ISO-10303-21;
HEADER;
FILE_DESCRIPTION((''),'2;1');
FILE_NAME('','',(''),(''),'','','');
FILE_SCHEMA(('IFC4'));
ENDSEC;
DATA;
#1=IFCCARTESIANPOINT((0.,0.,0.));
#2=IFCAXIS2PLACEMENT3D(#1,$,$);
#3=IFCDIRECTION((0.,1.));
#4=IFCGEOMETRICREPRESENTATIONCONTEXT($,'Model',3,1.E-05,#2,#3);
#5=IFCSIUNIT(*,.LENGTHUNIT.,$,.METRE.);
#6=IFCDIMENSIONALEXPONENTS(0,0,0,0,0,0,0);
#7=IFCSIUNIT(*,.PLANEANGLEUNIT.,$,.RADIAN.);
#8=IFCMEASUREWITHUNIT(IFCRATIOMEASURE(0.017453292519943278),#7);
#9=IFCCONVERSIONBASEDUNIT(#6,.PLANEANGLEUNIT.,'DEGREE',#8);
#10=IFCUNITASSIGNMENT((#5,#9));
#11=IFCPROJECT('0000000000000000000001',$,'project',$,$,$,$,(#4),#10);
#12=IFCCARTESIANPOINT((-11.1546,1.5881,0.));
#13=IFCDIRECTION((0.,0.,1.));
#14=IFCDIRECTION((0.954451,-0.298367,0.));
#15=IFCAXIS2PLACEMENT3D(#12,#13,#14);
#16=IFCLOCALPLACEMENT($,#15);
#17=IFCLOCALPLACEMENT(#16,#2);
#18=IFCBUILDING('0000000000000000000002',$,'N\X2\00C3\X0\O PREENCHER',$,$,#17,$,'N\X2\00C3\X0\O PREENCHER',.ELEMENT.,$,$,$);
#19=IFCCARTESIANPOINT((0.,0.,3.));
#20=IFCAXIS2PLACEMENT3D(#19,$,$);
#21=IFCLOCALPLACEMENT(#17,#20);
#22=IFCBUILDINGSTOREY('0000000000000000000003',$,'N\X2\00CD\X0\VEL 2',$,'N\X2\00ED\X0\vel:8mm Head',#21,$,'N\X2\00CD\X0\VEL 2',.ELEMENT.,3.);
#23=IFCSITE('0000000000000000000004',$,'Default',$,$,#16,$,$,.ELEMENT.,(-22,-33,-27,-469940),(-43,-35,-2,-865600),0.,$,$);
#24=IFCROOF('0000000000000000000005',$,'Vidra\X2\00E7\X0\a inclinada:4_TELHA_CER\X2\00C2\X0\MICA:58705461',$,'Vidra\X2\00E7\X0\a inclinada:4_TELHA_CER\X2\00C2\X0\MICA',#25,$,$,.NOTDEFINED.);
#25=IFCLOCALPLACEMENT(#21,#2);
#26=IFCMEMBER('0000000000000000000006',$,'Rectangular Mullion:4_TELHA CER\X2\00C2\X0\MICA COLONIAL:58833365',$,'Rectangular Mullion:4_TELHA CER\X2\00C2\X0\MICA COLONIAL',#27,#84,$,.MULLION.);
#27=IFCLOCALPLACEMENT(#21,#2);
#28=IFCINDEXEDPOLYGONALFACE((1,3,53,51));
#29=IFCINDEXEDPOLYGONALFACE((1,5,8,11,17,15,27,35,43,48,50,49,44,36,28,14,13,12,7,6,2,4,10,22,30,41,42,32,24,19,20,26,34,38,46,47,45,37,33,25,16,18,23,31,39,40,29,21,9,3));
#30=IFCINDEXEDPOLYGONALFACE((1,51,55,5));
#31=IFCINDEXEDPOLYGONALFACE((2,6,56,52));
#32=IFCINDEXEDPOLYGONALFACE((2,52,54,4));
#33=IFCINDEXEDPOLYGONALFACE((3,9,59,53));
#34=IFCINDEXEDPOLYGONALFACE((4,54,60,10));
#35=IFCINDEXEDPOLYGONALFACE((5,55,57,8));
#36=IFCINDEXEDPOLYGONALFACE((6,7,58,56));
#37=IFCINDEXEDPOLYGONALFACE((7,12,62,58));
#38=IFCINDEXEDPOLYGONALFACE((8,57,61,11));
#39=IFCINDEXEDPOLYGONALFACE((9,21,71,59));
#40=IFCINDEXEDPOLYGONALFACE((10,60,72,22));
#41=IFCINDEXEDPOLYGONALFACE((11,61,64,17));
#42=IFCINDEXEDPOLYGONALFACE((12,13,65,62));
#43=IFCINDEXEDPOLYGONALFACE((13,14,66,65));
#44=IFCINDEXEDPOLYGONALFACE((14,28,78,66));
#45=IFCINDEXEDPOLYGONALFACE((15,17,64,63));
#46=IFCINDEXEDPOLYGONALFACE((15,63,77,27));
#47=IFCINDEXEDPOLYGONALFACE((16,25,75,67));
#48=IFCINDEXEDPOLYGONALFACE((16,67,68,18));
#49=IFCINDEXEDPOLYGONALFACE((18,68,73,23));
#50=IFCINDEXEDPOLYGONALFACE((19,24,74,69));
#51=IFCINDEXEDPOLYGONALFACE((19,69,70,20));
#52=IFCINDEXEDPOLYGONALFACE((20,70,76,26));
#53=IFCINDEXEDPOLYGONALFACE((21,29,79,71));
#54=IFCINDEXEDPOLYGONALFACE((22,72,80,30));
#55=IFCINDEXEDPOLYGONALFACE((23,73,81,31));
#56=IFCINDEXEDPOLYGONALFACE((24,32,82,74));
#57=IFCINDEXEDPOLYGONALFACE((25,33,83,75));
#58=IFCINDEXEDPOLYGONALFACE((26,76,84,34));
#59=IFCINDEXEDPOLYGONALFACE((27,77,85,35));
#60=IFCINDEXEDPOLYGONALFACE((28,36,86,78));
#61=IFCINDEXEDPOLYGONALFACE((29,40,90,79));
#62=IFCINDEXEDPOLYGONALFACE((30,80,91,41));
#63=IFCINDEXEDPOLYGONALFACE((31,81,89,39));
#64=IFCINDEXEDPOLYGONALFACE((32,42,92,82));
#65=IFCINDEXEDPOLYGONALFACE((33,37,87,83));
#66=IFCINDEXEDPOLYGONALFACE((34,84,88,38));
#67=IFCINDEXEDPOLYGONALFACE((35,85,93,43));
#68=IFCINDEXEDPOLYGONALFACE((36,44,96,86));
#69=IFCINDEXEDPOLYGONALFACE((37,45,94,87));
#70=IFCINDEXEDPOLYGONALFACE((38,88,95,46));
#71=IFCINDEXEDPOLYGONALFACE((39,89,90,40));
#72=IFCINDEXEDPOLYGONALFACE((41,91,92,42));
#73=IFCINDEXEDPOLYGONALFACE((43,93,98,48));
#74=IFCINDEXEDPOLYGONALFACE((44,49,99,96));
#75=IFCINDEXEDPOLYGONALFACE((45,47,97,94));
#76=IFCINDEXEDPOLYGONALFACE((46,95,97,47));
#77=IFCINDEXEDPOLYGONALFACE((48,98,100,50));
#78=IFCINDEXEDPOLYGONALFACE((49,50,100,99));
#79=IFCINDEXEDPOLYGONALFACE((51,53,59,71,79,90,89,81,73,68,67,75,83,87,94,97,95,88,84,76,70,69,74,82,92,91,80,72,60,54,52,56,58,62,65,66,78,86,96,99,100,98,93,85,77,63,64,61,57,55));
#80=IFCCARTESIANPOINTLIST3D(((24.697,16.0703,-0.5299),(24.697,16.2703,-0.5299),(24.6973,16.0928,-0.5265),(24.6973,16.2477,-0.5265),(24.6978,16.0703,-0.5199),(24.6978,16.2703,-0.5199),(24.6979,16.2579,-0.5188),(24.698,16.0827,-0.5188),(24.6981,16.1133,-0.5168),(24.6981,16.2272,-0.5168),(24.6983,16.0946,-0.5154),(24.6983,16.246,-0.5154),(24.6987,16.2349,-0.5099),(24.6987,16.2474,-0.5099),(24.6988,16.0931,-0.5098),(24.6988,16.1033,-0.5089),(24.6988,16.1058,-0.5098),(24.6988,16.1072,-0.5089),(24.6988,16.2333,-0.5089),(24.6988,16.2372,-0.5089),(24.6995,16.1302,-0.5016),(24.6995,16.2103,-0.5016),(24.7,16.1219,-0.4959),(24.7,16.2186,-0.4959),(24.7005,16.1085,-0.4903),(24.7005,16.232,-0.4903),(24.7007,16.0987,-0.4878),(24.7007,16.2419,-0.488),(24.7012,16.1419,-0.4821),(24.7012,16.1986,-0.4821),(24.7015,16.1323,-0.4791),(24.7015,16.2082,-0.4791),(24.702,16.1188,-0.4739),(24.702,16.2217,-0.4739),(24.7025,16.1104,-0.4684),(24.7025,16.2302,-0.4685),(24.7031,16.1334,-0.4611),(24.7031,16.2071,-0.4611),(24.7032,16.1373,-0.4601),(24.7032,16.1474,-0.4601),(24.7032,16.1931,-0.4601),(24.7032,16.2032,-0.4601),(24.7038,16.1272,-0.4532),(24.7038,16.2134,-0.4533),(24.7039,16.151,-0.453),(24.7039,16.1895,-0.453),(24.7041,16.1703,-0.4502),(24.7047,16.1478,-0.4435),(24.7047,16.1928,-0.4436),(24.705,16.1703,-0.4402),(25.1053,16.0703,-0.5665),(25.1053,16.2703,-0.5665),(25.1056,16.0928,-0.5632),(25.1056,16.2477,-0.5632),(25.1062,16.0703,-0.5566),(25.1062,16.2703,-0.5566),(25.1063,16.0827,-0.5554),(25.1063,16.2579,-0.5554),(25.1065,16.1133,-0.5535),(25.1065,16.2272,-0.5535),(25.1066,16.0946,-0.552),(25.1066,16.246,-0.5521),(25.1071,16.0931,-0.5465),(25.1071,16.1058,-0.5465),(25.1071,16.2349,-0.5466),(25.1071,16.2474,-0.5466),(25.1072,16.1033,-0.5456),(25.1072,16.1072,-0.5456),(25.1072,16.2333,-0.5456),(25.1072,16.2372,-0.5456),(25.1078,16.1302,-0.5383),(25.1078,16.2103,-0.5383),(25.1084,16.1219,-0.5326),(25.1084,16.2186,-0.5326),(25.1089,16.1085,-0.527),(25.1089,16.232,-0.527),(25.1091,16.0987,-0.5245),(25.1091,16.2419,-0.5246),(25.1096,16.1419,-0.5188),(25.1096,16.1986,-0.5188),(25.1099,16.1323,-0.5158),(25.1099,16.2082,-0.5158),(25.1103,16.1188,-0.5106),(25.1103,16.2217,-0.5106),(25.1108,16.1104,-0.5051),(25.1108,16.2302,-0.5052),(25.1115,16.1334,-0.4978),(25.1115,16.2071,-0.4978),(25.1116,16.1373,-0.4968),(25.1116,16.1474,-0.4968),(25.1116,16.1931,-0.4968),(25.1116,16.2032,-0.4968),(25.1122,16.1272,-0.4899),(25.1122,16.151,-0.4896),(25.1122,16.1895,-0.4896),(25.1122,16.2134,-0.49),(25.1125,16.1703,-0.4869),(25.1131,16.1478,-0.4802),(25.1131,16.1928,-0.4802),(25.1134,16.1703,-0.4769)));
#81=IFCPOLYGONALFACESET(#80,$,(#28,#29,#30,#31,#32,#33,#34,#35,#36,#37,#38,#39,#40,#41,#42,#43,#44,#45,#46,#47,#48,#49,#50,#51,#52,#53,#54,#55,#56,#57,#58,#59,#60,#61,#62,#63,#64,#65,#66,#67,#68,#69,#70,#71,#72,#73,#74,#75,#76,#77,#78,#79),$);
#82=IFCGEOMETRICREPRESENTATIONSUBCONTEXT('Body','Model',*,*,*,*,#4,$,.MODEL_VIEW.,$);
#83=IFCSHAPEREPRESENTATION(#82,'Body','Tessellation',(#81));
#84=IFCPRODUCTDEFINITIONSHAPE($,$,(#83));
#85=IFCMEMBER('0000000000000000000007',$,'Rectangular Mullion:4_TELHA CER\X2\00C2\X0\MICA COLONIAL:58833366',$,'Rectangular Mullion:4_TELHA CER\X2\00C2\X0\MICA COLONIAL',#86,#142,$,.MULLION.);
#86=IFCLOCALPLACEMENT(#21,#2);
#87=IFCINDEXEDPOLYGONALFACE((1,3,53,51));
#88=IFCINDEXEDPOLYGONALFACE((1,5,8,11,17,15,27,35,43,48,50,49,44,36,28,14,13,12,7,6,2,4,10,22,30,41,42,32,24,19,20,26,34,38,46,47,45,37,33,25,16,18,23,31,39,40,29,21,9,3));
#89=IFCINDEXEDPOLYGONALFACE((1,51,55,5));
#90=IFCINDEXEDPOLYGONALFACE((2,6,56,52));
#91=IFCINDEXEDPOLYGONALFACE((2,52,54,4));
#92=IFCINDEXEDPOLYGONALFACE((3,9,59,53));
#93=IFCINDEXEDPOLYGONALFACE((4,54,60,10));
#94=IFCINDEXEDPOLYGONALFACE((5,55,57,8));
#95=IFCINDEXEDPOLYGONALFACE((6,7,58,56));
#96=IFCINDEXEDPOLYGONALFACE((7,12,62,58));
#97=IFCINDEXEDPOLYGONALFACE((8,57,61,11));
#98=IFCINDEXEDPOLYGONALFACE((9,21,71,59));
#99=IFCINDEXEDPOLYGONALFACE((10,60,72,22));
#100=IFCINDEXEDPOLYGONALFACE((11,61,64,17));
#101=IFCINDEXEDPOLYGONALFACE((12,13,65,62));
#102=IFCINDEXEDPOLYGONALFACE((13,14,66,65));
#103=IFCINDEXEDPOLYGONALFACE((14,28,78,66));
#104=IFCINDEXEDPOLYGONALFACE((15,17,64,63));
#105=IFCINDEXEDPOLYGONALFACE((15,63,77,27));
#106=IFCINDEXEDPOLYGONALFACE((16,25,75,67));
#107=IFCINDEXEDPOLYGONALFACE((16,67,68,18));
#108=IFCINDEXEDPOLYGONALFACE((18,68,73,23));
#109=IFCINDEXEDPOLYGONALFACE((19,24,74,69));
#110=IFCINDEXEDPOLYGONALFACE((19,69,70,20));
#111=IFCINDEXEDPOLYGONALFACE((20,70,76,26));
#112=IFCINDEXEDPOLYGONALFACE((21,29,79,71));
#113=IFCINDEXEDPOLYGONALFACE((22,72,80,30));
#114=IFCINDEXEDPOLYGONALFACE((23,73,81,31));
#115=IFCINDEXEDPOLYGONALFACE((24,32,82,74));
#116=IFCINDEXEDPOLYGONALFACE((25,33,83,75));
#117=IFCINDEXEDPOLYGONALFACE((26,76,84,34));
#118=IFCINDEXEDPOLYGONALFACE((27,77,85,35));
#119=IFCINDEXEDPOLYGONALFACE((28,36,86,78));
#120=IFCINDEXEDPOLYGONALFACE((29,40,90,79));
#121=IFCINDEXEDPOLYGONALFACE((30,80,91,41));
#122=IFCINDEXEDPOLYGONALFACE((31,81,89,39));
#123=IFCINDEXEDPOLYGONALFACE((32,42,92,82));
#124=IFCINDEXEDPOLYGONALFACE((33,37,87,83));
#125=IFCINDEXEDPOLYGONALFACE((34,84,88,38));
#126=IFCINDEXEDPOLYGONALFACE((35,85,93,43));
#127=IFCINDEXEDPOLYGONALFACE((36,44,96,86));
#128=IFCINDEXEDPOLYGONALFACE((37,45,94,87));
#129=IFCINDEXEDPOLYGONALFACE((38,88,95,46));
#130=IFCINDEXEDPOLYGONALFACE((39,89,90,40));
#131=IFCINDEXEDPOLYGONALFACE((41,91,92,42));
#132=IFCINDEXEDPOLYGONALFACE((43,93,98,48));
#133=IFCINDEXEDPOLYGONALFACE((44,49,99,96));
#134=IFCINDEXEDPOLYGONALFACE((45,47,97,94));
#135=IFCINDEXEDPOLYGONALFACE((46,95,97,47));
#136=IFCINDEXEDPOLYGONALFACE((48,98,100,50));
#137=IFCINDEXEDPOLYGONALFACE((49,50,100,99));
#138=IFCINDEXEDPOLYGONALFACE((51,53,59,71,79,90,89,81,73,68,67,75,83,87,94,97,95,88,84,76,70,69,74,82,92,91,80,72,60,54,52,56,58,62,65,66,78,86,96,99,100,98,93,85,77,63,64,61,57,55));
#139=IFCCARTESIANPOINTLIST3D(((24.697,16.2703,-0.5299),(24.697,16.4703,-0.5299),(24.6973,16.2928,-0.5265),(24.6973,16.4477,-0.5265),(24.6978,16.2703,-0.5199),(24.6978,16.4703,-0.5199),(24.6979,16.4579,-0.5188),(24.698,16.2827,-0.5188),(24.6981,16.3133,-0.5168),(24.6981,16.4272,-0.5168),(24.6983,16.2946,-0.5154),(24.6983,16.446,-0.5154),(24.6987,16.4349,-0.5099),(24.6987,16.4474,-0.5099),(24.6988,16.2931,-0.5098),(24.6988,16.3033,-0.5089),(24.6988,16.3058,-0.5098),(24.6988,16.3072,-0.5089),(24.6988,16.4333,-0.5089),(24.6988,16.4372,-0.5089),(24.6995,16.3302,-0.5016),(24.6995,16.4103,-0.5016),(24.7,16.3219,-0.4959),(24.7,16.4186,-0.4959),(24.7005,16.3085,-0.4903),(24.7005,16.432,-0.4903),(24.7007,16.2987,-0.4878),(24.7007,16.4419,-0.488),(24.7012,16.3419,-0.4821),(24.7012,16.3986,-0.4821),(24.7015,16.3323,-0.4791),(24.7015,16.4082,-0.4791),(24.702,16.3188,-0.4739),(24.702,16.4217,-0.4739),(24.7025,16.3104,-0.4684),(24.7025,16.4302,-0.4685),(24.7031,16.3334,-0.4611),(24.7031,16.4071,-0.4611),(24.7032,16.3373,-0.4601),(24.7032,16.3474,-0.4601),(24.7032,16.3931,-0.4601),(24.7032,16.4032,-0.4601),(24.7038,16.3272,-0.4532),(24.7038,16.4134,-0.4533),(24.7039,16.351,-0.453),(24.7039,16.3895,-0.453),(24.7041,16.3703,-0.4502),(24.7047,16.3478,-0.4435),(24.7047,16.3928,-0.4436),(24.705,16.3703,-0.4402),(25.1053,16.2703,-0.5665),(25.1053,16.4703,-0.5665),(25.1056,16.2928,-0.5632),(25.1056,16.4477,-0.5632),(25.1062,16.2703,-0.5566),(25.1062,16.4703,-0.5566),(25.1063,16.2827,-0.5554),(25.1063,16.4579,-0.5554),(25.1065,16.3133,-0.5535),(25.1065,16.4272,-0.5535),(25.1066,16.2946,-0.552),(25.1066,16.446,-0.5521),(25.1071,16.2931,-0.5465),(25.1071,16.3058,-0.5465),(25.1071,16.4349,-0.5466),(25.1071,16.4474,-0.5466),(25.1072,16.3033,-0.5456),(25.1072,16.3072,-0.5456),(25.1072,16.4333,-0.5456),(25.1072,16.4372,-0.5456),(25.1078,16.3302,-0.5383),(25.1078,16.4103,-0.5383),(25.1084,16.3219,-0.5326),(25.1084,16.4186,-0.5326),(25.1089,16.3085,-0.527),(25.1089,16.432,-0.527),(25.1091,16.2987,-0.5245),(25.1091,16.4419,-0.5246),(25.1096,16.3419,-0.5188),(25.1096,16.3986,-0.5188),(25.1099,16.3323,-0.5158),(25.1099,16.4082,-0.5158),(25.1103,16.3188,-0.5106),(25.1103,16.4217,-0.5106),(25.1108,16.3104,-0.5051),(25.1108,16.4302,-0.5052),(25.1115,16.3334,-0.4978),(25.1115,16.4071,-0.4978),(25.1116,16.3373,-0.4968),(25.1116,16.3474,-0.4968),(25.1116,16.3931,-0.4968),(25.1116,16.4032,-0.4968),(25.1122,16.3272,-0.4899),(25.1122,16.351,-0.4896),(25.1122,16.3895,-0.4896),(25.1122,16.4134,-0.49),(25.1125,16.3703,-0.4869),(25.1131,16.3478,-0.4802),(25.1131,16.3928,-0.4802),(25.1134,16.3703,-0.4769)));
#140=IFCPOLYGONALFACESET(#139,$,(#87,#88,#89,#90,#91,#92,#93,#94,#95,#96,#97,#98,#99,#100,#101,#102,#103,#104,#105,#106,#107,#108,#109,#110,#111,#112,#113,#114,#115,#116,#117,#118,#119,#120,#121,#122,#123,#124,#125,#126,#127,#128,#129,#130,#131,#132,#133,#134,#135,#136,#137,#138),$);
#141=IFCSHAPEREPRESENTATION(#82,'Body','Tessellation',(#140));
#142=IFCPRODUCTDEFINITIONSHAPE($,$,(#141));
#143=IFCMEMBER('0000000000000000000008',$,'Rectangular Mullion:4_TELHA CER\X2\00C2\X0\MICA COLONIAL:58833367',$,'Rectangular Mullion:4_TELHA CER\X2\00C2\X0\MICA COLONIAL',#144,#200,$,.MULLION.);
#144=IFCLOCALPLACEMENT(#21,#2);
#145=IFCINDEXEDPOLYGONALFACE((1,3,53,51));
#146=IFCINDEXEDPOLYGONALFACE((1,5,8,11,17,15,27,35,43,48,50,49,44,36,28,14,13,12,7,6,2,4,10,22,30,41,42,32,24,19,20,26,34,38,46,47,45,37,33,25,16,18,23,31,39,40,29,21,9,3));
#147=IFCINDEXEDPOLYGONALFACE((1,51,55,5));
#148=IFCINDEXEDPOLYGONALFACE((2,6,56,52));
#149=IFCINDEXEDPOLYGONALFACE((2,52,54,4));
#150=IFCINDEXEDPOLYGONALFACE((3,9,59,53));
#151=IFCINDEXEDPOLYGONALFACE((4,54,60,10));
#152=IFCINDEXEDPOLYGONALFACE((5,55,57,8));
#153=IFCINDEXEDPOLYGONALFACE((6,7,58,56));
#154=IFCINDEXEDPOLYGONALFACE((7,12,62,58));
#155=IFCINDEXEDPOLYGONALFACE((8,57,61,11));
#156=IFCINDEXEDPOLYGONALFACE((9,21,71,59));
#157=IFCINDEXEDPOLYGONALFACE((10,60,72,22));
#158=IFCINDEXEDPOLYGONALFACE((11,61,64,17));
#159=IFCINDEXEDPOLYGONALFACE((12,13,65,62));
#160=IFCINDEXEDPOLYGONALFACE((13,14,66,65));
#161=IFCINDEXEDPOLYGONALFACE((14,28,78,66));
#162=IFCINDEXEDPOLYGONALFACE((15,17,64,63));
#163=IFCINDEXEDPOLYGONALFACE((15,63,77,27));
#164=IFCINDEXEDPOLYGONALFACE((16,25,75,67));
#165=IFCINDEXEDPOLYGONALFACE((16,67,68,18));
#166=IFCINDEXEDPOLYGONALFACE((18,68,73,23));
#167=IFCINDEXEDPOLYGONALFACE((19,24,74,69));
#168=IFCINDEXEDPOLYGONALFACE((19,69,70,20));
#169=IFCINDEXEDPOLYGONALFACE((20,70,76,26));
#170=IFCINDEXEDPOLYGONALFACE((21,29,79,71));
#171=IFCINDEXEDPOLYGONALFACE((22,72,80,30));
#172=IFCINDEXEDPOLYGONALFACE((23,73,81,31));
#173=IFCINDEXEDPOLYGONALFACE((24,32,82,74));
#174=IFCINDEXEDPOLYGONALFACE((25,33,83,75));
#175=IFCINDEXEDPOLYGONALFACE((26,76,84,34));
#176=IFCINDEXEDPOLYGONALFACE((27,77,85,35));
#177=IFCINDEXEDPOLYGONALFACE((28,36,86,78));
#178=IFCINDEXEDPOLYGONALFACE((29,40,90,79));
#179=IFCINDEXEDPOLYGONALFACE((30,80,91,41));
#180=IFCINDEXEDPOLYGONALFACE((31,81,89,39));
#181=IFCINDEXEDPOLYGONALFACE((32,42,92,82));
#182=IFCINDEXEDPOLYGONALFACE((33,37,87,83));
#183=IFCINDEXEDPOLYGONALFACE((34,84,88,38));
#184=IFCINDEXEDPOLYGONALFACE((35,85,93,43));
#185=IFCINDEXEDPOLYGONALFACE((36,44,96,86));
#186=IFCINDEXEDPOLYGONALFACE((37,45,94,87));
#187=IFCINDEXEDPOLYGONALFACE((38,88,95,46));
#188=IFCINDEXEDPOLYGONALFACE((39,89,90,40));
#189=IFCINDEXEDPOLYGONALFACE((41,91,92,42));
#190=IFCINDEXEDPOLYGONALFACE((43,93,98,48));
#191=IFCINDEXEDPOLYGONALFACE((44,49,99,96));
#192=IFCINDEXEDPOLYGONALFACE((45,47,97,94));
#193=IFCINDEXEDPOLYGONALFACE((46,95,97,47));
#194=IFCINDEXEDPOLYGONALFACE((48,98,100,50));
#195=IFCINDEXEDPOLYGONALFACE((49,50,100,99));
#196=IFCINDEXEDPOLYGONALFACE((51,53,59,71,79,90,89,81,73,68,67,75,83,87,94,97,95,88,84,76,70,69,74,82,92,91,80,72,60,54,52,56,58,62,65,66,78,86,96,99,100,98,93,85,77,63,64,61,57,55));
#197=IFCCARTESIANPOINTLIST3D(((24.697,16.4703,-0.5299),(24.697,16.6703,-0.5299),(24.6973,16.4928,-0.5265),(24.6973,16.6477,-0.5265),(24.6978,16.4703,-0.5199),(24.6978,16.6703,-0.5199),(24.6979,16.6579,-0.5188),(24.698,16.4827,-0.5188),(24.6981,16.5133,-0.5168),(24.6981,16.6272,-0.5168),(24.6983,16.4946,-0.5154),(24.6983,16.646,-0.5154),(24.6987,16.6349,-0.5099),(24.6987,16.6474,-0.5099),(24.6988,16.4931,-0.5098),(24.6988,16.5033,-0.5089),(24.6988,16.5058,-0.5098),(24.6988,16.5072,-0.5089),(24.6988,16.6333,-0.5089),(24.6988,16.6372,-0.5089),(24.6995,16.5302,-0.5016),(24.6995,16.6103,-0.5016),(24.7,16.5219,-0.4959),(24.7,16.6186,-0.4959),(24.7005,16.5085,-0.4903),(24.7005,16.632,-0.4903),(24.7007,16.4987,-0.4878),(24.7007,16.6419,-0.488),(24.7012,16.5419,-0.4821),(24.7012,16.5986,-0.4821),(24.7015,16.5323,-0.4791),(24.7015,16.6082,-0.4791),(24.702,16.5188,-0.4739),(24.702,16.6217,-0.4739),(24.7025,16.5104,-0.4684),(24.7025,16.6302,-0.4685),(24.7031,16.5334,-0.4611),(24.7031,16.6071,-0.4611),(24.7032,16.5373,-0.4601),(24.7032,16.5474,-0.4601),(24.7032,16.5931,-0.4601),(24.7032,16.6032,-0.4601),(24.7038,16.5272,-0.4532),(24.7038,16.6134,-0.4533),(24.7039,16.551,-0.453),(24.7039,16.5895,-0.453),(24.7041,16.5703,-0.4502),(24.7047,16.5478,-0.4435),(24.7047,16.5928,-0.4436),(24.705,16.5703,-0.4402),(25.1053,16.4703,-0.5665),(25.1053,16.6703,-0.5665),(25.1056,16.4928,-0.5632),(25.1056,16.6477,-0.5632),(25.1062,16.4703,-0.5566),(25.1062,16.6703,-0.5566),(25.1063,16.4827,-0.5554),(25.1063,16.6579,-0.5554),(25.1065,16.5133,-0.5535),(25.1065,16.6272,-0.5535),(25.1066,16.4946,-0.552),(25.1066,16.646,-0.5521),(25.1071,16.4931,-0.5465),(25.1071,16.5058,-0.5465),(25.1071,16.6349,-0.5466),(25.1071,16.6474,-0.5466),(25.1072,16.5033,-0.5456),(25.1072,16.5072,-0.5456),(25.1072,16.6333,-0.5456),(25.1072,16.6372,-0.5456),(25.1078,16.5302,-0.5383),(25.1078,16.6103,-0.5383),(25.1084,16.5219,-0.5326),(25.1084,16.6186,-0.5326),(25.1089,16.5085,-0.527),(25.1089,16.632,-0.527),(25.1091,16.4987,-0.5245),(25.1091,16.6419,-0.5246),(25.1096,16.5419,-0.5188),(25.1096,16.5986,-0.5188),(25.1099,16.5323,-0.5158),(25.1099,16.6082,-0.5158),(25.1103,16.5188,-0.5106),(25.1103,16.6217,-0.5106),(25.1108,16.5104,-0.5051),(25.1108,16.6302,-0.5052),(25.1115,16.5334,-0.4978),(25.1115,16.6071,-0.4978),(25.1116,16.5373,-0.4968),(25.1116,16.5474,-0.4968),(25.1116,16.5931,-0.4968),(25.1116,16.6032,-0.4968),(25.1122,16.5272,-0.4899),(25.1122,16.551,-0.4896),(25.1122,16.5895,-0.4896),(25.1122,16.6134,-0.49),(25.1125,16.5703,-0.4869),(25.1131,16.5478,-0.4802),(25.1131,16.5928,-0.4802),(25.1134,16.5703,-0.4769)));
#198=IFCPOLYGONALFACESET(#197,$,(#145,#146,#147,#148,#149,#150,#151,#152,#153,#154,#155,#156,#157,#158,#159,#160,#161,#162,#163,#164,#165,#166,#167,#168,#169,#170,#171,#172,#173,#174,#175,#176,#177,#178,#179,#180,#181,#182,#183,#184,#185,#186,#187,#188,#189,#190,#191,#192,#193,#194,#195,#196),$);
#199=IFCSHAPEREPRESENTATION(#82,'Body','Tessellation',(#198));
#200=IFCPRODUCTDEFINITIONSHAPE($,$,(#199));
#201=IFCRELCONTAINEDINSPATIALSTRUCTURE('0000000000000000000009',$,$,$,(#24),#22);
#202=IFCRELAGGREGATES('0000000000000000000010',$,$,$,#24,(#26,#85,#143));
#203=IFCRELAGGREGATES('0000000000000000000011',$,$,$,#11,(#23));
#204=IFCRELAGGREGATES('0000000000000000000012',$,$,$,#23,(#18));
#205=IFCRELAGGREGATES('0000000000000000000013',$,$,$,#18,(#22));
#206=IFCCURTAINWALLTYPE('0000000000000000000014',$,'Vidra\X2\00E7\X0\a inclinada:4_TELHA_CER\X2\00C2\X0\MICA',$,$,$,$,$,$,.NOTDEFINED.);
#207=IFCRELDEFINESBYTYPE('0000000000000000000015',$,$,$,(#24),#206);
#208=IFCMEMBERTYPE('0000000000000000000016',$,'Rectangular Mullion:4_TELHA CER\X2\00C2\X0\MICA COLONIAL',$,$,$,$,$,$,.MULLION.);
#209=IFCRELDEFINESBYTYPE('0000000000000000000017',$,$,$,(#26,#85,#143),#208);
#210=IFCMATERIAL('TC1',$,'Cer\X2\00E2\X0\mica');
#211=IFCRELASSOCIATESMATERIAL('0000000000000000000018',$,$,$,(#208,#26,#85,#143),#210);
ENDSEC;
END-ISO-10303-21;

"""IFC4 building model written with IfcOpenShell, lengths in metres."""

from ifc_helpers import new_model, entity, si_unit, converted_unit, direction, frame, origin, place, context, subcontext, project, spatial, line, arc, indexed_curve, outline, extrude, source, transform, mapped, material, type_object, type_shapes, element, aggregate, save


model = new_model("IFC4")

# Units and contexts
model_context = context("Model", 3, precision=1e-05, world=origin(), true_north=direction((0.0, 1.0)))
body_context = subcontext(model_context, "Body", "Model", "MODEL_VIEW")
ifc_project = project(units=[si_unit("LENGTHUNIT", "METRE"), converted_unit("PLANEANGLEUNIT", "DEGREE", entity("IfcRatioMeasure", 0.017453292519943278), si_unit("PLANEANGLEUNIT", "RADIAN"), dimensions=[0, 0, 0, 0, 0, 0, 0])], contexts=[model_context])

# Site, building, storey
site_placement = place(None, frame((-11.1546, 1.5881, 0.0), z_axis=(0.0, 0.0, 1.0), x_axis=(0.954451, -0.298367, 0.0)))
site = spatial("IfcSite", under=ifc_project, at=site_placement, Name="Default", CompositionType="ELEMENT", RefLatitude=(-22, -33, -27, -469940), RefLongitude=(-43, -35, -2, -865600), RefElevation=0.0)
building_placement = place(site_placement, origin())
building = spatial("IfcBuilding", under=site, at=building_placement, Name="NÃO PREENCHER", LongName="NÃO PREENCHER", CompositionType="ELEMENT")
storey_placement = place(building_placement, frame((0.0, 0.0, 3.0)))
storey = spatial("IfcBuildingStorey", under=building, at=storey_placement, Name="NÍVEL 2", ObjectType="Nível:8mm Head", LongName="NÍVEL 2", CompositionType="ELEMENT", Elevation=3.0)

# Roof, members
curtain_wall_type = type_object("IfcCurtainWallType", Name="Vidraça inclinada:4_TELHA_CERÂMICA", PredefinedType="NOTDEFINED")
roof_placement = place(storey_placement, frame((0.0, 0.0, -3.0)))
roof = element("IfcRoof", 1, at=roof_placement, inside=storey, type_object=curtain_wall_type, Name="Vidraça inclinada:4_TELHA_CERÂMICA:58705461", ObjectType="Vidraça inclinada:4_TELHA_CERÂMICA", PredefinedType="NOTDEFINED")
ifc_material = material(Name="TC1", Category="Cerâmica")
member_type = type_object("IfcMemberType", Name="Rectangular Mullion:4_TELHA CERÂMICA COLONIAL", PredefinedType="MULLION", material=ifc_material)
shared_shape = source(origin(), body_context, "Body", "SweptSolid", [
    extrude(outline(indexed_curve([(-0.029, -0.1), (-0.019, -0.1), (-0.0164, -0.0815), (-0.0089, -0.0645), (-0.0089, -0.0771), (0.061, 0.0), (-0.009, 0.0771), (-0.009, 0.0646), (-0.0165, 0.0816), (-0.019, 0.1), (-0.029, 0.1), (-0.0089, 0.0479), (0.041, 0.0229), (0.041, 0.0329), (0.0131, 0.0425), (-0.008, 0.0631), (-0.008, 0.067), (0.051, 0.0), (-0.008, -0.067), (-0.008, -0.0631), (0.0131, -0.0425), (0.041, -0.0329), (0.041, -0.0229), (-0.0089, -0.0479)], segments=[line(1, 2), arc(2, 3, 4), line(4, 5), arc(5, 6, 7), line(7, 8), arc(8, 9, 10), line(10, 11), arc(11, 12, 13), line(13, 14), arc(14, 15, 16), line(16, 17), arc(17, 18, 19), line(19, 20), arc(20, 21, 22), line(22, 23), arc(23, 24, 1)], self_intersect=False)), frame((0.0, -0.029, -0.41), z_axis=(0.0, 0.0, 1.0), x_axis=(0.0, -1.0, 0.0)), (0.0, 0.0, 1.0), 0.41),
])
type_shapes(member_type, [shared_shape])
member_1_placement = place(roof_placement, frame((24.697, 16.1703, 2.4701), z_axis=(-0.99599, 0.0, 0.089469), x_axis=(0.0, 1.0, 0.0)))
member_1 = element("IfcMember", 2, at=member_1_placement, type_object=member_type, material=ifc_material, Name="Rectangular Mullion:4_TELHA CERÂMICA COLONIAL:58833365", ObjectType="Rectangular Mullion:4_TELHA CERÂMICA COLONIAL", PredefinedType="MULLION", context=body_context, shape_type="MappedRepresentation", body=[
    mapped(shared_shape, transform((0.0, 0.0, 0.0), scale=1.0)),
])
member_2_placement = place(roof_placement, frame((24.697, 16.3703, 2.4701), z_axis=(-0.99599, 0.0, 0.089469), x_axis=(0.0, 1.0, 0.0)))
member_2 = element("IfcMember", 3, at=member_2_placement, type_object=member_type, material=ifc_material, Name="Rectangular Mullion:4_TELHA CERÂMICA COLONIAL:58833366", ObjectType="Rectangular Mullion:4_TELHA CERÂMICA COLONIAL", PredefinedType="MULLION", context=body_context, shape_type="MappedRepresentation", body=[
    mapped(shared_shape, transform((0.0, 0.0, 0.0), scale=1.0)),
])
member_3_placement = place(roof_placement, frame((24.697, 16.5703, 2.4701), z_axis=(-0.99599, 0.0, 0.089469), x_axis=(0.0, 1.0, 0.0)))
member_3 = element("IfcMember", 4, at=member_3_placement, type_object=member_type, material=ifc_material, Name="Rectangular Mullion:4_TELHA CERÂMICA COLONIAL:58833367", ObjectType="Rectangular Mullion:4_TELHA CERÂMICA COLONIAL", PredefinedType="MULLION", context=body_context, shape_type="MappedRepresentation", body=[
    mapped(shared_shape, transform((0.0, 0.0, 0.0), scale=1.0)),
])
aggregate(roof, [member_1, member_2, member_3])

save(model, "model.ifc")
